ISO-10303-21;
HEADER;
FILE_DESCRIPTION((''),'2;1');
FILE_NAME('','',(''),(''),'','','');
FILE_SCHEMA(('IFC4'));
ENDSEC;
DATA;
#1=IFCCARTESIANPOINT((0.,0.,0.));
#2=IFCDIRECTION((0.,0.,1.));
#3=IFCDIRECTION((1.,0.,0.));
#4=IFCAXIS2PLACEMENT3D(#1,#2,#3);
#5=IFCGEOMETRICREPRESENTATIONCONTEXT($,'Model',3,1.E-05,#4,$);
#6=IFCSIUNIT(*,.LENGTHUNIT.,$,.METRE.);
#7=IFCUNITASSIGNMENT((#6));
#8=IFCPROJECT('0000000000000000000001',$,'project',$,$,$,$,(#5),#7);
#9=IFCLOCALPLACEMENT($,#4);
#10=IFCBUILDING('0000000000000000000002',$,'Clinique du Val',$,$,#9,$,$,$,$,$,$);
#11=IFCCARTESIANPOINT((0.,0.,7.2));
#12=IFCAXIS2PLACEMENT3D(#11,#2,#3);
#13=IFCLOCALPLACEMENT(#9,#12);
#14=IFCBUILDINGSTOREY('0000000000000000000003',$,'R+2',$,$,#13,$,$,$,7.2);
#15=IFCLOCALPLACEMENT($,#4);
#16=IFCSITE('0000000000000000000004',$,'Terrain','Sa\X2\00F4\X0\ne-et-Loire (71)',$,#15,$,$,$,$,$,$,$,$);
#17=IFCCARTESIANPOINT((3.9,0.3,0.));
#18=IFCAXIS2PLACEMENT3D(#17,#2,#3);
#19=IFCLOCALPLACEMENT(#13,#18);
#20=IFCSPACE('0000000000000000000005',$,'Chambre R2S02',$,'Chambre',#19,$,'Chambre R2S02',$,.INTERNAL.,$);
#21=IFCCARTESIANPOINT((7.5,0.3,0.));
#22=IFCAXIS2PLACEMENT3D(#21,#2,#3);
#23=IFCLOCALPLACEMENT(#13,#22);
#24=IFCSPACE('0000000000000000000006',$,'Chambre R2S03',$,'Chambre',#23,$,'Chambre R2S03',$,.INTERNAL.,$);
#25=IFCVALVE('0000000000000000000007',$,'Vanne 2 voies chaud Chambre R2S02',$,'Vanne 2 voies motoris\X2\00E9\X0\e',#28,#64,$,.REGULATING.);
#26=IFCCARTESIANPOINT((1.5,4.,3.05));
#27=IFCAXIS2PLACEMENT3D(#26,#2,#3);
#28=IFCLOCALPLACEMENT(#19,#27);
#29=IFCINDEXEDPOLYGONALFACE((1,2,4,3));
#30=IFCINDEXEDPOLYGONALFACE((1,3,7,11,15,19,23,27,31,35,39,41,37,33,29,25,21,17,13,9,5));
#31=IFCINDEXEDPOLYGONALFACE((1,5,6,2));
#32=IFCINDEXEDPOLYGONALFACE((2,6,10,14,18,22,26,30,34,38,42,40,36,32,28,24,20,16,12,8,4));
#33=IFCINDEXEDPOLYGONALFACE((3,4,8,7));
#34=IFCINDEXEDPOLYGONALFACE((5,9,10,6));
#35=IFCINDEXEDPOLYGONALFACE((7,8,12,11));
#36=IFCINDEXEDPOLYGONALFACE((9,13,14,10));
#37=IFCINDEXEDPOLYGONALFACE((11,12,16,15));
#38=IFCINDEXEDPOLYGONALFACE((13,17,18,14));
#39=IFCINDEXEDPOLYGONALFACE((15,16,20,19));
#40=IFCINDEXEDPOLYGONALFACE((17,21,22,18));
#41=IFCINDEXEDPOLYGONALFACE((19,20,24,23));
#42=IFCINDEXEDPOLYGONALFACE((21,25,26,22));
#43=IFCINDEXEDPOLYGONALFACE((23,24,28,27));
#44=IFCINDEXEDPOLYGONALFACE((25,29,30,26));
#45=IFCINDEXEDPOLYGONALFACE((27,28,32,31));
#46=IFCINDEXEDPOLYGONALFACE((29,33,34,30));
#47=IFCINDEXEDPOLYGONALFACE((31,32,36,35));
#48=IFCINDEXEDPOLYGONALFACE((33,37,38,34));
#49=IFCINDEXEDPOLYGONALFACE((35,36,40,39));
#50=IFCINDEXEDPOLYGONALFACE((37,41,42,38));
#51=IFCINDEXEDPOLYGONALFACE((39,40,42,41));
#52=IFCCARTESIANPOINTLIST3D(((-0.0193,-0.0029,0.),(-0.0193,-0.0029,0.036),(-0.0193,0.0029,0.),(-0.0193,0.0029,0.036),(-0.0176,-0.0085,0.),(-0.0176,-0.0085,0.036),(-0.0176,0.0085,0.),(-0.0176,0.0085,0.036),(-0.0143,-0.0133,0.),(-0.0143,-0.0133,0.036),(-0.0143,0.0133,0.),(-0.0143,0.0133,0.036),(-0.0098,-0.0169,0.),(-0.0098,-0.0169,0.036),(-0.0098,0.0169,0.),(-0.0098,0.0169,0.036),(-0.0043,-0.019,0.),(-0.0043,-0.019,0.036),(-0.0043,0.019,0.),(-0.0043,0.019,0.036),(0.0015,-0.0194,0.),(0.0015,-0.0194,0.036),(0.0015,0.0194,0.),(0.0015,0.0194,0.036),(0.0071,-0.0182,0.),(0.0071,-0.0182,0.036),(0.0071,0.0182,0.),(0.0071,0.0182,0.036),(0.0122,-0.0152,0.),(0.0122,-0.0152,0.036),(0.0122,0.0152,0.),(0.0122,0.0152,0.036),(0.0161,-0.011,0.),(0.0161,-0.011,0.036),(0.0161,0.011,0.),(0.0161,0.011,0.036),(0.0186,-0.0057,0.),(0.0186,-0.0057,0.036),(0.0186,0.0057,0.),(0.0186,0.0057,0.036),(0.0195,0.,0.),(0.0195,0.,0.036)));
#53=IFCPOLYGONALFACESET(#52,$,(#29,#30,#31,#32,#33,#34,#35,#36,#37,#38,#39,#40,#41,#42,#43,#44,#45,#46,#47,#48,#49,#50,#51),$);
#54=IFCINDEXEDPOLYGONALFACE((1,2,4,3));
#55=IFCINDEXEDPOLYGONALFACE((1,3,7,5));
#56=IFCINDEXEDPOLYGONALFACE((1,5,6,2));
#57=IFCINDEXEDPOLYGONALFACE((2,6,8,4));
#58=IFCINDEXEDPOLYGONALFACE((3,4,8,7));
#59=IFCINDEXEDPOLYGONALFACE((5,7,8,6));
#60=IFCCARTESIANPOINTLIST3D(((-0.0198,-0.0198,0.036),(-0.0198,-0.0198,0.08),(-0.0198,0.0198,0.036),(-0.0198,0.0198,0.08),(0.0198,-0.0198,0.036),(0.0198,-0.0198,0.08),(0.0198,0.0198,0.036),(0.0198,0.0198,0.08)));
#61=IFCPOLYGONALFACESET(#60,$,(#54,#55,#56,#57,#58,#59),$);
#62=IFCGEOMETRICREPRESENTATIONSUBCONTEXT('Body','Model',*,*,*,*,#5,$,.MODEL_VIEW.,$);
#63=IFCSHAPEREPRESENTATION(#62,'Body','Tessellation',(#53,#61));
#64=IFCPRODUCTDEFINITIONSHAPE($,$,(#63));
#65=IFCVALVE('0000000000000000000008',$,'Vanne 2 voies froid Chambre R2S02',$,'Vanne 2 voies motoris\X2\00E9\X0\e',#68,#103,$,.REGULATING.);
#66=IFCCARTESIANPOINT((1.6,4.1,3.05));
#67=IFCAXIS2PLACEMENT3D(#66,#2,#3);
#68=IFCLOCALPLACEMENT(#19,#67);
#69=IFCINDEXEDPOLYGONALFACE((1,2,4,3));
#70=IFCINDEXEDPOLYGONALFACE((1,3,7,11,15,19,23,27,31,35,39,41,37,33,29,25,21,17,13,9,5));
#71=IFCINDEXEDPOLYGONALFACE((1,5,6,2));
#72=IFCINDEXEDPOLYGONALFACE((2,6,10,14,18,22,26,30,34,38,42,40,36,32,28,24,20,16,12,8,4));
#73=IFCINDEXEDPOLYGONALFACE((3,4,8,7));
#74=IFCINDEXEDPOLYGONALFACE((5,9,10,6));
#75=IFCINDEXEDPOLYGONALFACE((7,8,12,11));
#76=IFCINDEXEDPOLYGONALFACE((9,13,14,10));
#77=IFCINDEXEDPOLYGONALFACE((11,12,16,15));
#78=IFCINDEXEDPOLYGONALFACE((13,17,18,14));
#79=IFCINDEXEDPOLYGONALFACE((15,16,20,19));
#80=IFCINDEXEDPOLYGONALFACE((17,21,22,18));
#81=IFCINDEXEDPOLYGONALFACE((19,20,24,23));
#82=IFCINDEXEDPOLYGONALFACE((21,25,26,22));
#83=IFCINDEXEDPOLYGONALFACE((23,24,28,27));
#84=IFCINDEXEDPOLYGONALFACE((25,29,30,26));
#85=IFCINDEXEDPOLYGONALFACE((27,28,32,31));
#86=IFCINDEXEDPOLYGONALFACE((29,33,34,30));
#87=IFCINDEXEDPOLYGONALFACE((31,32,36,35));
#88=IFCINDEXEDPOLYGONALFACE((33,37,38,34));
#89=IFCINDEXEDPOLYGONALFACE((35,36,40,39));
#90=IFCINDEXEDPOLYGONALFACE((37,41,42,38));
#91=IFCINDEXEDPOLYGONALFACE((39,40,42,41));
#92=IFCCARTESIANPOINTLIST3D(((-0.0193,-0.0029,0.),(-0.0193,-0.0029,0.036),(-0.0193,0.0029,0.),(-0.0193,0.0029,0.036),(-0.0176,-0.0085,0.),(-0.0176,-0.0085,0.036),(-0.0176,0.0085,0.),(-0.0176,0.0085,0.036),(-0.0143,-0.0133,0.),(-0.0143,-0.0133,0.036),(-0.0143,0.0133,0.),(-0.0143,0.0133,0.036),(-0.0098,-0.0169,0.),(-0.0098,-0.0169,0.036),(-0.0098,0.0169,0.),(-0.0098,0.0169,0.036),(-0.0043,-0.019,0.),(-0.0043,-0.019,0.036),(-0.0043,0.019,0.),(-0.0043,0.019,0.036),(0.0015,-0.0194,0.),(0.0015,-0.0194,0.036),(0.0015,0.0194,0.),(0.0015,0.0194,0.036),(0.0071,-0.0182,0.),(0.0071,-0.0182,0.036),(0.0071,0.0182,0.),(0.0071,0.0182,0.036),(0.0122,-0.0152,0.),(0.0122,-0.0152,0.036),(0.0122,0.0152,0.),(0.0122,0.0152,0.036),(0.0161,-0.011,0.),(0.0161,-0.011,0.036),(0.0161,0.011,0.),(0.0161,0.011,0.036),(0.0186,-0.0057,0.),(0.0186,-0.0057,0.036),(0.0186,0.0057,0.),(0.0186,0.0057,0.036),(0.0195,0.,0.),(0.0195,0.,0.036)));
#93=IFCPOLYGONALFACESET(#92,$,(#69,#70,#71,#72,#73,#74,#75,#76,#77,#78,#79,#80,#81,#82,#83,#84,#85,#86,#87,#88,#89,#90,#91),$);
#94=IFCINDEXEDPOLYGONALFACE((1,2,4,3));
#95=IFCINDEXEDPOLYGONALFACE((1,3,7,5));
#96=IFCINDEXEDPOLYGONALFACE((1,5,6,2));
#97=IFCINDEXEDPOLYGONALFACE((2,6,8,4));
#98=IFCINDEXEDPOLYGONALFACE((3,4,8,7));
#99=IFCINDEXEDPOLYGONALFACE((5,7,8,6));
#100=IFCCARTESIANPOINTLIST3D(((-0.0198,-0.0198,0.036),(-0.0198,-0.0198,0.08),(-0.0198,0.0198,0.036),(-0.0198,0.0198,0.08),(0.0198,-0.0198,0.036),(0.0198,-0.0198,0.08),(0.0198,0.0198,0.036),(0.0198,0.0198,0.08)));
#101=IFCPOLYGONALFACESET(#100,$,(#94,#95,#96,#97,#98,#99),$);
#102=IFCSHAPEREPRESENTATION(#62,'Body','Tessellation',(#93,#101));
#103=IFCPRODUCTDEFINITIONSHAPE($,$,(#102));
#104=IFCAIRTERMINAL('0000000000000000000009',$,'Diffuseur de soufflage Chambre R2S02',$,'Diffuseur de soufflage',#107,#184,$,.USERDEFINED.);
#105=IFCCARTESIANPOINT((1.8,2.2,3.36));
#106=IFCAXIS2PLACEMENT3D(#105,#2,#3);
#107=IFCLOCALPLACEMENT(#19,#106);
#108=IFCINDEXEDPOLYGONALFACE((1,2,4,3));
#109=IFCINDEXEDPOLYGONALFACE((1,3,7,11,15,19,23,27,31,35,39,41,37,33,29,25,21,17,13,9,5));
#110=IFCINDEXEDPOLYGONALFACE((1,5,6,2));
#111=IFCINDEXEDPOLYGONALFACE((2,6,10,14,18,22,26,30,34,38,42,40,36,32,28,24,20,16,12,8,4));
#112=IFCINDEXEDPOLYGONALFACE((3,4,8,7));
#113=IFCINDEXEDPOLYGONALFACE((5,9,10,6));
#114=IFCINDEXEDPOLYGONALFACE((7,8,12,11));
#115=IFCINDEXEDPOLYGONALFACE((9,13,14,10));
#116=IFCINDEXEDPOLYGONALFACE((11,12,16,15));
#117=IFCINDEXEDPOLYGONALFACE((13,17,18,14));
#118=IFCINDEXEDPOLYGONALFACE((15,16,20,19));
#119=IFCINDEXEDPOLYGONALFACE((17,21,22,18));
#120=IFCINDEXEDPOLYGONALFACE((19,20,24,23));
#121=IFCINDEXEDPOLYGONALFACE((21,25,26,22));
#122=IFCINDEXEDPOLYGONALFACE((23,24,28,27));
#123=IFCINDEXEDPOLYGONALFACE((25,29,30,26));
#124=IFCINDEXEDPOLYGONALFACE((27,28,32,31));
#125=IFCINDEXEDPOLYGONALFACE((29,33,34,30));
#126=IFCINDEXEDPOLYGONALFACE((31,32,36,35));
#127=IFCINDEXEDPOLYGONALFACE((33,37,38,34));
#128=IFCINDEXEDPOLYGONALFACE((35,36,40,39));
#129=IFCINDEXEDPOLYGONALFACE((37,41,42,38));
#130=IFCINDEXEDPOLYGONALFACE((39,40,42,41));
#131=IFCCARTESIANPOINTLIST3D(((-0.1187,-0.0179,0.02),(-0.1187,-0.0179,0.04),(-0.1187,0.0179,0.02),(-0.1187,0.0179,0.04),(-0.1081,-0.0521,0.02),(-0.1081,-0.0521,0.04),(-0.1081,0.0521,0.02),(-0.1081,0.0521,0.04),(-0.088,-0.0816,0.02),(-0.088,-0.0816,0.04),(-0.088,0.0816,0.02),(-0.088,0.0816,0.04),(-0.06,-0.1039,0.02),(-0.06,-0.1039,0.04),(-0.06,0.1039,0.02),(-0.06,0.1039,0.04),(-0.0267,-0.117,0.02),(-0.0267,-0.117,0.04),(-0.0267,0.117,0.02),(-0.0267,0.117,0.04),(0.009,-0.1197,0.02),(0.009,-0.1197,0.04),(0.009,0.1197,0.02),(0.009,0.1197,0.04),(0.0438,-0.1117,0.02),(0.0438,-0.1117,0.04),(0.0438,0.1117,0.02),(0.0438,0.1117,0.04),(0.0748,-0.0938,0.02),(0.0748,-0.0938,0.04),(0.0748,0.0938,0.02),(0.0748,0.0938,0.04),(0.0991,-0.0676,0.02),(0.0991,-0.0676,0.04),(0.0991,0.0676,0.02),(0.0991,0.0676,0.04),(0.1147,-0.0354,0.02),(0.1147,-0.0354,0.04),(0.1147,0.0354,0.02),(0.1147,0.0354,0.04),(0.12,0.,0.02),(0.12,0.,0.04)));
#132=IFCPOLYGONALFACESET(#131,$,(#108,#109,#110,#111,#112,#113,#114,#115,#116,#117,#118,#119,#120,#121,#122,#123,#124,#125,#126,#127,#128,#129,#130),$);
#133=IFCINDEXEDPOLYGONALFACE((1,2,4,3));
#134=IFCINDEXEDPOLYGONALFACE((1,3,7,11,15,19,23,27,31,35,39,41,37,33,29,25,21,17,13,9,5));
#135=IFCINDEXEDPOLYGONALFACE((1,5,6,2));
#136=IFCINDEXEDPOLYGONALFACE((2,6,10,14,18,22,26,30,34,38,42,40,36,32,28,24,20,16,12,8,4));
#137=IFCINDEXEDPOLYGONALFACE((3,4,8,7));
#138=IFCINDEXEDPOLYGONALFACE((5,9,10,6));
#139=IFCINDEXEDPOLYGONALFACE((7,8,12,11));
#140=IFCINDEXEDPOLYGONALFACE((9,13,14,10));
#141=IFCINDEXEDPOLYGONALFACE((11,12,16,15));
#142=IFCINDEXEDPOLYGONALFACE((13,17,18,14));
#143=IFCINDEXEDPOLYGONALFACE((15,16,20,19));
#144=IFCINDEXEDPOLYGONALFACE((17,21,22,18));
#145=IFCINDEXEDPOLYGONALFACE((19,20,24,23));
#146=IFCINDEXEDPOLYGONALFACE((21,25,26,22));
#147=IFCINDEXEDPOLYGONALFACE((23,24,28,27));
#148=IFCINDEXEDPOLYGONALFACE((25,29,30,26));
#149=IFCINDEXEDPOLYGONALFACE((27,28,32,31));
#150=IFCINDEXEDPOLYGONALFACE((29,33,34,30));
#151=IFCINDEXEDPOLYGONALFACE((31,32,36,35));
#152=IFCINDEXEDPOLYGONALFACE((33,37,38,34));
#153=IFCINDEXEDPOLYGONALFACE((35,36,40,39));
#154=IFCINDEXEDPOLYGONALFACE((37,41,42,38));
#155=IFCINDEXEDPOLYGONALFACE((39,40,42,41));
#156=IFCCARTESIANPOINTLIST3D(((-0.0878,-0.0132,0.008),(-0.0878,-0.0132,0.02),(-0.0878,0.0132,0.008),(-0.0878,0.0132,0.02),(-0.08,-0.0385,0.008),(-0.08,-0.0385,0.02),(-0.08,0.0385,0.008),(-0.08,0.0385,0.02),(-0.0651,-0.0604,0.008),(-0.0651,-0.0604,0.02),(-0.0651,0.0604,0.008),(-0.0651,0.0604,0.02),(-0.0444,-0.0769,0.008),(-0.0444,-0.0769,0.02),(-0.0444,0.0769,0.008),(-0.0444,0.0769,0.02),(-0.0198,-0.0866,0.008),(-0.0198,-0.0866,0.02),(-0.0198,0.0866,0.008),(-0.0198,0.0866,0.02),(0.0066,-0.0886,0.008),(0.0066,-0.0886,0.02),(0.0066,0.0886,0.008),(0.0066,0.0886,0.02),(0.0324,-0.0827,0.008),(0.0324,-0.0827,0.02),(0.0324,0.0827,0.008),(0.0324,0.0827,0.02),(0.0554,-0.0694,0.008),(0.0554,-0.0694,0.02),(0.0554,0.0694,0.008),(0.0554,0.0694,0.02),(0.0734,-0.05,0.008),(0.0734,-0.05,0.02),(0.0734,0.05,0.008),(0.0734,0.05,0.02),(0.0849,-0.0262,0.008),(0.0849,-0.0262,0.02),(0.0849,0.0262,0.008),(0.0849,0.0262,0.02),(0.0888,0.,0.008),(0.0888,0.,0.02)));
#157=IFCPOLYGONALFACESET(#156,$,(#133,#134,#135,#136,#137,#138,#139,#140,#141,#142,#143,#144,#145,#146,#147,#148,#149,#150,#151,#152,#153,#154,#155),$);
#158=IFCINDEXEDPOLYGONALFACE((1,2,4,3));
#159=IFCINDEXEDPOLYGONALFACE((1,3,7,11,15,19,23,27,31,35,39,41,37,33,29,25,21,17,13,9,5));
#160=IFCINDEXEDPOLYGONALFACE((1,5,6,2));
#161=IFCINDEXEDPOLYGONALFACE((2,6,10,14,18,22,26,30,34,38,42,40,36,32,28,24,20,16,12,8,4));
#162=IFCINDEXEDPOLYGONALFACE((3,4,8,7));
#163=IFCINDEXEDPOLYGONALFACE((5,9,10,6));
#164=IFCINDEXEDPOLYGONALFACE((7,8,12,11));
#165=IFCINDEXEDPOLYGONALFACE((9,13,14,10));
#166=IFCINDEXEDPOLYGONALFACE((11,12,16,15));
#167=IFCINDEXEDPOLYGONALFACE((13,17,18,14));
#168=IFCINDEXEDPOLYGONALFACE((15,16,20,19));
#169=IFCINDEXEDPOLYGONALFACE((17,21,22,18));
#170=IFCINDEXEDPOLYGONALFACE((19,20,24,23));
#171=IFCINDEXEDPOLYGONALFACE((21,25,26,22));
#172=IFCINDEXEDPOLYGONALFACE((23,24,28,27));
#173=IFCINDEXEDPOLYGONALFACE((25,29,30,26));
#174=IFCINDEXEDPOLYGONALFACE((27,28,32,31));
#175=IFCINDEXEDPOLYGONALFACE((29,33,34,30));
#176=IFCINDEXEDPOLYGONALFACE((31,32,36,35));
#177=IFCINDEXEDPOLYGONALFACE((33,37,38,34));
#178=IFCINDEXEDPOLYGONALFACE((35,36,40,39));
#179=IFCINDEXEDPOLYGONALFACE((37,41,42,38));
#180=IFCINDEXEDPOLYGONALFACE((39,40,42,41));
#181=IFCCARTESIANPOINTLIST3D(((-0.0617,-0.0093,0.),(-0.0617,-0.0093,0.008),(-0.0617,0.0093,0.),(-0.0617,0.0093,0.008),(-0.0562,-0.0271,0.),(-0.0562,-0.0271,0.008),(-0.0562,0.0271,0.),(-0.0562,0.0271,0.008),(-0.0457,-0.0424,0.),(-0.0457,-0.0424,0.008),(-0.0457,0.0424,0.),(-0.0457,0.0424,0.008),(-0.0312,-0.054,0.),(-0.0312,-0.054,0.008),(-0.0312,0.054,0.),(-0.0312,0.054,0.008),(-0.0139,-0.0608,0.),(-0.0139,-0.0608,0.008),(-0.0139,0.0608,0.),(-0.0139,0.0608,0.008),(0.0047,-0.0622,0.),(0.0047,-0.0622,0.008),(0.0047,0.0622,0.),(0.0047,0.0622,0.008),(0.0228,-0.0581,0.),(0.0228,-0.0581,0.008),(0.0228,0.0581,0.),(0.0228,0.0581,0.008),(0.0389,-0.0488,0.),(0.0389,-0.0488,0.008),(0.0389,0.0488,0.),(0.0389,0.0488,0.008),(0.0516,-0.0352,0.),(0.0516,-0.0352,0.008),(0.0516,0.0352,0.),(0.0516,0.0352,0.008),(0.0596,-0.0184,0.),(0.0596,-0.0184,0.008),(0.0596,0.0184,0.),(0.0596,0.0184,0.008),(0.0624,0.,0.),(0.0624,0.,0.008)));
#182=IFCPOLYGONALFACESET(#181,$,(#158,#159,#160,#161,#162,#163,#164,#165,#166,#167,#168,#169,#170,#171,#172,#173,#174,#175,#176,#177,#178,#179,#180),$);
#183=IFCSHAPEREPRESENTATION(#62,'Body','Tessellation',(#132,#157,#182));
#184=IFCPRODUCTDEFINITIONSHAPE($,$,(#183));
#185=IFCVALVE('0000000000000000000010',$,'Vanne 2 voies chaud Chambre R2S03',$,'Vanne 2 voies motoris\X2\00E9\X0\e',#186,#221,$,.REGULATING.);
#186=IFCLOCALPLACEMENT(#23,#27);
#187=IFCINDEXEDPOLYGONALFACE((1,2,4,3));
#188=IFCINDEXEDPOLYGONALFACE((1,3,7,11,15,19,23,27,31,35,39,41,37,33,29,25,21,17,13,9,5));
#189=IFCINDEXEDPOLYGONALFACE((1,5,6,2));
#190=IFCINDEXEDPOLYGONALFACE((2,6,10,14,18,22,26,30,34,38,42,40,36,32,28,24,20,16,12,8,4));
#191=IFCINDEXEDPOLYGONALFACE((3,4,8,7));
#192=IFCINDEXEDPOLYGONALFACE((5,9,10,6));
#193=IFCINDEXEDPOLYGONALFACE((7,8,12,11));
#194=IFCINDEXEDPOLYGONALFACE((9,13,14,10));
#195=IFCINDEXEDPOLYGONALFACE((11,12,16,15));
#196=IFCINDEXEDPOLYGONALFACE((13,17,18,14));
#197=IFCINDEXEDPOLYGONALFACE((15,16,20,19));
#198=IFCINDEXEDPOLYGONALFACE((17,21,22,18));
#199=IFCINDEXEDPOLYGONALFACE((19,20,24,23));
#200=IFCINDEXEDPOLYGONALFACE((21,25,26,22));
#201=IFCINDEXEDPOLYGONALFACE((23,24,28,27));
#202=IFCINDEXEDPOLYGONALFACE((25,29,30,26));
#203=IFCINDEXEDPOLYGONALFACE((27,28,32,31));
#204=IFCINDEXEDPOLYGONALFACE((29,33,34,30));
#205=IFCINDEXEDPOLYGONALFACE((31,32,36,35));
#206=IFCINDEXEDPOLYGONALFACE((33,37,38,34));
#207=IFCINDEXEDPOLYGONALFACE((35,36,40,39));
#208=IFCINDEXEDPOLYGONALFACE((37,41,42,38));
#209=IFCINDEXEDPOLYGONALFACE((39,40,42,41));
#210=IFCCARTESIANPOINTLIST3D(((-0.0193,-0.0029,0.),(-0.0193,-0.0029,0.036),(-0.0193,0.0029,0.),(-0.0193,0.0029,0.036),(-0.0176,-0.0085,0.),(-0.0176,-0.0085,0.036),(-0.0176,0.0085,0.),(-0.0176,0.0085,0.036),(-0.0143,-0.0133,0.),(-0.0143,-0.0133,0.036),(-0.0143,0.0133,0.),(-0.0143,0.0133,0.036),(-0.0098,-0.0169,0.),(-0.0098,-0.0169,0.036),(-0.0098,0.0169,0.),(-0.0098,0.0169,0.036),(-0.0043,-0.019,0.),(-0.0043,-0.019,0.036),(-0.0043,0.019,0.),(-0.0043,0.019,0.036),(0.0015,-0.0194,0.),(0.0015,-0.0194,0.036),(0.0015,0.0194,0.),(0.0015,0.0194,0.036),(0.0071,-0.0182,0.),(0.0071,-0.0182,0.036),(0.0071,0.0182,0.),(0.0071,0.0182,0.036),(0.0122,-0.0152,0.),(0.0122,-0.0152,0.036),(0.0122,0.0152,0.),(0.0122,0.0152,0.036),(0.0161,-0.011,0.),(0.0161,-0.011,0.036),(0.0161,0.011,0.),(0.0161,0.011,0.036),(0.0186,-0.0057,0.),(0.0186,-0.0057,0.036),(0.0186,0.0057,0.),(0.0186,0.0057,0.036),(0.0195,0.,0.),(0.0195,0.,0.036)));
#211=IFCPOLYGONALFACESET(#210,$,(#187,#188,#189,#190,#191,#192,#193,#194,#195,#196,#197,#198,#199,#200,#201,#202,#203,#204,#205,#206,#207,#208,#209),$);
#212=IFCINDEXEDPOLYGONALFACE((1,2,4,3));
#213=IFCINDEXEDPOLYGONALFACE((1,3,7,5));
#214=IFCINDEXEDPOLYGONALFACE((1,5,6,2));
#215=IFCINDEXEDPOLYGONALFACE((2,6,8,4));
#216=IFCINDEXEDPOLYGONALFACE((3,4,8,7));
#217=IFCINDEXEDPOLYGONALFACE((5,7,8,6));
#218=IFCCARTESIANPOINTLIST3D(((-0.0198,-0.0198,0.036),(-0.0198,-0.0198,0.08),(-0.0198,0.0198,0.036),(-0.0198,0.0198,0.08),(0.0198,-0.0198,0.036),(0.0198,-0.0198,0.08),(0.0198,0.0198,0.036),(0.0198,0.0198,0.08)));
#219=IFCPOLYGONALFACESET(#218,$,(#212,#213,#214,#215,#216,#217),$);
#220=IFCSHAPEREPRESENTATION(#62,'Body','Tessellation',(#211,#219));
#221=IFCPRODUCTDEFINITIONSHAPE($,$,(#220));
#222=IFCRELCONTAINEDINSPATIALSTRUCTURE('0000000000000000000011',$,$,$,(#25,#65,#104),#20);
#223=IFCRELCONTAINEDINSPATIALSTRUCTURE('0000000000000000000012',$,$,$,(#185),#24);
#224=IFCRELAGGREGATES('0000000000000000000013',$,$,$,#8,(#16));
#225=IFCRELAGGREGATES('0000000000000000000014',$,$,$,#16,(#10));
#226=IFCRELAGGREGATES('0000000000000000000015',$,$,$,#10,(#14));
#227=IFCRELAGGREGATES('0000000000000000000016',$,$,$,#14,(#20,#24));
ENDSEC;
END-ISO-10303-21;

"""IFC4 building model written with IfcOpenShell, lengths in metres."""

from ifc_helpers import new_model, si_unit, frame, frame_2d, origin_with_axes, place, context, subcontext, project, spatial, rectangle, circle, extrude, element, save


model = new_model("IFC4")

# Units and contexts
model_context = context("Model", 3, precision=1e-05, world=origin_with_axes())
body_context = subcontext(model_context, "Body", "Model", "MODEL_VIEW")
ifc_project = project(units=[si_unit("LENGTHUNIT", "METRE")], contexts=[model_context])

# Site, building, storey
site_placement = place(None, origin_with_axes())
site = spatial("IfcSite", under=ifc_project, at=site_placement, Name="Terrain", Description="Saône-et-Loire (71)")
building_placement = place(None, origin_with_axes())
building = spatial("IfcBuilding", under=site, at=building_placement, Name="Clinique du Val")
storey_placement = place(building_placement, frame((0.0, 0.0, 7.2), z_axis=(0.0, 0.0, 1.0), x_axis=(1.0, 0.0, 0.0)))
storey = spatial("IfcBuildingStorey", under=building, at=storey_placement, Name="R+2", Elevation=7.2)

# Shared definitions
space_1_placement = place(storey_placement, frame((3.9, 0.3, 0.0), z_axis=(0.0, 0.0, 1.0), x_axis=(1.0, 0.0, 0.0)))
space_1 = spatial("IfcSpace", under=storey, at=space_1_placement, Name="Chambre R2S02", ObjectType="Chambre", LongName="Chambre R2S02", PredefinedType="INTERNAL")

# Valves
for number, where, z_axis, x_axis, name in (
    (1, (1.5, 4.0, 3.05), (0.0, 0.0, 1.0), (1.0, 0.0, 0.0), "Vanne 2 voies chaud Chambre R2S02"),
    (2, (1.6, 4.1, 3.05), (0.0, 0.0, 1.0), (1.0, 0.0, 0.0), "Vanne 2 voies froid Chambre R2S02"),
):
    element("IfcValve", number, at=place(space_1_placement, frame(where, z_axis=z_axis, x_axis=x_axis)), inside=space_1, Name=name, ObjectType="Vanne 2 voies motorisée", PredefinedType="REGULATING", context=body_context, shape_type="SweptSolid", body=[
        extrude(circle(Radius=0.0195), origin_with_axes(), (0.0, 0.0, 1.0), 0.036),
        extrude(rectangle(XDim=0.0396, YDim=0.0396, at=frame_2d((0.0198, 0.0198))), frame((-0.0198, -0.0198, 0.036), z_axis=(0.0, 0.0, 1.0), x_axis=(1.0, 0.0, 0.0)), (0.0, 0.0, 1.0), 0.044),
    ])

# Air terminal
air_terminal_1_placement = place(space_1_placement, frame((1.8, 2.2, 3.36), z_axis=(0.0, 0.0, 1.0), x_axis=(1.0, 0.0, 0.0)))
element("IfcAirTerminal", 3, at=air_terminal_1_placement, inside=space_1, Name="Diffuseur de soufflage Chambre R2S02", ObjectType="Diffuseur de soufflage", PredefinedType="USERDEFINED", context=body_context, shape_type="SweptSolid", body=[
    extrude(circle(Radius=0.12), frame((0.0, 0.0, 0.02), z_axis=(0.0, 0.0, 1.0), x_axis=(1.0, 0.0, 0.0)), (0.0, 0.0, 1.0), 0.02),
    extrude(circle(Radius=0.0888), frame((0.0, 0.0, 0.008), z_axis=(0.0, 0.0, 1.0), x_axis=(1.0, 0.0, 0.0)), (0.0, 0.0, 1.0), 0.012),
    extrude(circle(Radius=0.0624), origin_with_axes(), (0.0, 0.0, 1.0), 0.008),
])

# Shared definitions
space_2_placement = place(storey_placement, frame((7.5, 0.3, 0.0), z_axis=(0.0, 0.0, 1.0), x_axis=(1.0, 0.0, 0.0)))
space_2 = spatial("IfcSpace", under=storey, at=space_2_placement, Name="Chambre R2S03", ObjectType="Chambre", LongName="Chambre R2S03", PredefinedType="INTERNAL")

# Valve
for number, where, z_axis, x_axis, name in (
    (4, (1.5, 4.0, 3.05), (0.0, 0.0, 1.0), (1.0, 0.0, 0.0), "Vanne 2 voies chaud Chambre R2S03"),
):
    element("IfcValve", number, at=place(space_2_placement, frame(where, z_axis=z_axis, x_axis=x_axis)), inside=space_2, Name=name, ObjectType="Vanne 2 voies motorisée", PredefinedType="REGULATING", context=body_context, shape_type="SweptSolid", body=[
        extrude(circle(Radius=0.0195), origin_with_axes(), (0.0, 0.0, 1.0), 0.036),
        extrude(rectangle(XDim=0.0396, YDim=0.0396, at=frame_2d((0.0198, 0.0198))), frame((-0.0198, -0.0198, 0.036), z_axis=(0.0, 0.0, 1.0), x_axis=(1.0, 0.0, 0.0)), (0.0, 0.0, 1.0), 0.044),
    ])

save(model, "model.ifc")
